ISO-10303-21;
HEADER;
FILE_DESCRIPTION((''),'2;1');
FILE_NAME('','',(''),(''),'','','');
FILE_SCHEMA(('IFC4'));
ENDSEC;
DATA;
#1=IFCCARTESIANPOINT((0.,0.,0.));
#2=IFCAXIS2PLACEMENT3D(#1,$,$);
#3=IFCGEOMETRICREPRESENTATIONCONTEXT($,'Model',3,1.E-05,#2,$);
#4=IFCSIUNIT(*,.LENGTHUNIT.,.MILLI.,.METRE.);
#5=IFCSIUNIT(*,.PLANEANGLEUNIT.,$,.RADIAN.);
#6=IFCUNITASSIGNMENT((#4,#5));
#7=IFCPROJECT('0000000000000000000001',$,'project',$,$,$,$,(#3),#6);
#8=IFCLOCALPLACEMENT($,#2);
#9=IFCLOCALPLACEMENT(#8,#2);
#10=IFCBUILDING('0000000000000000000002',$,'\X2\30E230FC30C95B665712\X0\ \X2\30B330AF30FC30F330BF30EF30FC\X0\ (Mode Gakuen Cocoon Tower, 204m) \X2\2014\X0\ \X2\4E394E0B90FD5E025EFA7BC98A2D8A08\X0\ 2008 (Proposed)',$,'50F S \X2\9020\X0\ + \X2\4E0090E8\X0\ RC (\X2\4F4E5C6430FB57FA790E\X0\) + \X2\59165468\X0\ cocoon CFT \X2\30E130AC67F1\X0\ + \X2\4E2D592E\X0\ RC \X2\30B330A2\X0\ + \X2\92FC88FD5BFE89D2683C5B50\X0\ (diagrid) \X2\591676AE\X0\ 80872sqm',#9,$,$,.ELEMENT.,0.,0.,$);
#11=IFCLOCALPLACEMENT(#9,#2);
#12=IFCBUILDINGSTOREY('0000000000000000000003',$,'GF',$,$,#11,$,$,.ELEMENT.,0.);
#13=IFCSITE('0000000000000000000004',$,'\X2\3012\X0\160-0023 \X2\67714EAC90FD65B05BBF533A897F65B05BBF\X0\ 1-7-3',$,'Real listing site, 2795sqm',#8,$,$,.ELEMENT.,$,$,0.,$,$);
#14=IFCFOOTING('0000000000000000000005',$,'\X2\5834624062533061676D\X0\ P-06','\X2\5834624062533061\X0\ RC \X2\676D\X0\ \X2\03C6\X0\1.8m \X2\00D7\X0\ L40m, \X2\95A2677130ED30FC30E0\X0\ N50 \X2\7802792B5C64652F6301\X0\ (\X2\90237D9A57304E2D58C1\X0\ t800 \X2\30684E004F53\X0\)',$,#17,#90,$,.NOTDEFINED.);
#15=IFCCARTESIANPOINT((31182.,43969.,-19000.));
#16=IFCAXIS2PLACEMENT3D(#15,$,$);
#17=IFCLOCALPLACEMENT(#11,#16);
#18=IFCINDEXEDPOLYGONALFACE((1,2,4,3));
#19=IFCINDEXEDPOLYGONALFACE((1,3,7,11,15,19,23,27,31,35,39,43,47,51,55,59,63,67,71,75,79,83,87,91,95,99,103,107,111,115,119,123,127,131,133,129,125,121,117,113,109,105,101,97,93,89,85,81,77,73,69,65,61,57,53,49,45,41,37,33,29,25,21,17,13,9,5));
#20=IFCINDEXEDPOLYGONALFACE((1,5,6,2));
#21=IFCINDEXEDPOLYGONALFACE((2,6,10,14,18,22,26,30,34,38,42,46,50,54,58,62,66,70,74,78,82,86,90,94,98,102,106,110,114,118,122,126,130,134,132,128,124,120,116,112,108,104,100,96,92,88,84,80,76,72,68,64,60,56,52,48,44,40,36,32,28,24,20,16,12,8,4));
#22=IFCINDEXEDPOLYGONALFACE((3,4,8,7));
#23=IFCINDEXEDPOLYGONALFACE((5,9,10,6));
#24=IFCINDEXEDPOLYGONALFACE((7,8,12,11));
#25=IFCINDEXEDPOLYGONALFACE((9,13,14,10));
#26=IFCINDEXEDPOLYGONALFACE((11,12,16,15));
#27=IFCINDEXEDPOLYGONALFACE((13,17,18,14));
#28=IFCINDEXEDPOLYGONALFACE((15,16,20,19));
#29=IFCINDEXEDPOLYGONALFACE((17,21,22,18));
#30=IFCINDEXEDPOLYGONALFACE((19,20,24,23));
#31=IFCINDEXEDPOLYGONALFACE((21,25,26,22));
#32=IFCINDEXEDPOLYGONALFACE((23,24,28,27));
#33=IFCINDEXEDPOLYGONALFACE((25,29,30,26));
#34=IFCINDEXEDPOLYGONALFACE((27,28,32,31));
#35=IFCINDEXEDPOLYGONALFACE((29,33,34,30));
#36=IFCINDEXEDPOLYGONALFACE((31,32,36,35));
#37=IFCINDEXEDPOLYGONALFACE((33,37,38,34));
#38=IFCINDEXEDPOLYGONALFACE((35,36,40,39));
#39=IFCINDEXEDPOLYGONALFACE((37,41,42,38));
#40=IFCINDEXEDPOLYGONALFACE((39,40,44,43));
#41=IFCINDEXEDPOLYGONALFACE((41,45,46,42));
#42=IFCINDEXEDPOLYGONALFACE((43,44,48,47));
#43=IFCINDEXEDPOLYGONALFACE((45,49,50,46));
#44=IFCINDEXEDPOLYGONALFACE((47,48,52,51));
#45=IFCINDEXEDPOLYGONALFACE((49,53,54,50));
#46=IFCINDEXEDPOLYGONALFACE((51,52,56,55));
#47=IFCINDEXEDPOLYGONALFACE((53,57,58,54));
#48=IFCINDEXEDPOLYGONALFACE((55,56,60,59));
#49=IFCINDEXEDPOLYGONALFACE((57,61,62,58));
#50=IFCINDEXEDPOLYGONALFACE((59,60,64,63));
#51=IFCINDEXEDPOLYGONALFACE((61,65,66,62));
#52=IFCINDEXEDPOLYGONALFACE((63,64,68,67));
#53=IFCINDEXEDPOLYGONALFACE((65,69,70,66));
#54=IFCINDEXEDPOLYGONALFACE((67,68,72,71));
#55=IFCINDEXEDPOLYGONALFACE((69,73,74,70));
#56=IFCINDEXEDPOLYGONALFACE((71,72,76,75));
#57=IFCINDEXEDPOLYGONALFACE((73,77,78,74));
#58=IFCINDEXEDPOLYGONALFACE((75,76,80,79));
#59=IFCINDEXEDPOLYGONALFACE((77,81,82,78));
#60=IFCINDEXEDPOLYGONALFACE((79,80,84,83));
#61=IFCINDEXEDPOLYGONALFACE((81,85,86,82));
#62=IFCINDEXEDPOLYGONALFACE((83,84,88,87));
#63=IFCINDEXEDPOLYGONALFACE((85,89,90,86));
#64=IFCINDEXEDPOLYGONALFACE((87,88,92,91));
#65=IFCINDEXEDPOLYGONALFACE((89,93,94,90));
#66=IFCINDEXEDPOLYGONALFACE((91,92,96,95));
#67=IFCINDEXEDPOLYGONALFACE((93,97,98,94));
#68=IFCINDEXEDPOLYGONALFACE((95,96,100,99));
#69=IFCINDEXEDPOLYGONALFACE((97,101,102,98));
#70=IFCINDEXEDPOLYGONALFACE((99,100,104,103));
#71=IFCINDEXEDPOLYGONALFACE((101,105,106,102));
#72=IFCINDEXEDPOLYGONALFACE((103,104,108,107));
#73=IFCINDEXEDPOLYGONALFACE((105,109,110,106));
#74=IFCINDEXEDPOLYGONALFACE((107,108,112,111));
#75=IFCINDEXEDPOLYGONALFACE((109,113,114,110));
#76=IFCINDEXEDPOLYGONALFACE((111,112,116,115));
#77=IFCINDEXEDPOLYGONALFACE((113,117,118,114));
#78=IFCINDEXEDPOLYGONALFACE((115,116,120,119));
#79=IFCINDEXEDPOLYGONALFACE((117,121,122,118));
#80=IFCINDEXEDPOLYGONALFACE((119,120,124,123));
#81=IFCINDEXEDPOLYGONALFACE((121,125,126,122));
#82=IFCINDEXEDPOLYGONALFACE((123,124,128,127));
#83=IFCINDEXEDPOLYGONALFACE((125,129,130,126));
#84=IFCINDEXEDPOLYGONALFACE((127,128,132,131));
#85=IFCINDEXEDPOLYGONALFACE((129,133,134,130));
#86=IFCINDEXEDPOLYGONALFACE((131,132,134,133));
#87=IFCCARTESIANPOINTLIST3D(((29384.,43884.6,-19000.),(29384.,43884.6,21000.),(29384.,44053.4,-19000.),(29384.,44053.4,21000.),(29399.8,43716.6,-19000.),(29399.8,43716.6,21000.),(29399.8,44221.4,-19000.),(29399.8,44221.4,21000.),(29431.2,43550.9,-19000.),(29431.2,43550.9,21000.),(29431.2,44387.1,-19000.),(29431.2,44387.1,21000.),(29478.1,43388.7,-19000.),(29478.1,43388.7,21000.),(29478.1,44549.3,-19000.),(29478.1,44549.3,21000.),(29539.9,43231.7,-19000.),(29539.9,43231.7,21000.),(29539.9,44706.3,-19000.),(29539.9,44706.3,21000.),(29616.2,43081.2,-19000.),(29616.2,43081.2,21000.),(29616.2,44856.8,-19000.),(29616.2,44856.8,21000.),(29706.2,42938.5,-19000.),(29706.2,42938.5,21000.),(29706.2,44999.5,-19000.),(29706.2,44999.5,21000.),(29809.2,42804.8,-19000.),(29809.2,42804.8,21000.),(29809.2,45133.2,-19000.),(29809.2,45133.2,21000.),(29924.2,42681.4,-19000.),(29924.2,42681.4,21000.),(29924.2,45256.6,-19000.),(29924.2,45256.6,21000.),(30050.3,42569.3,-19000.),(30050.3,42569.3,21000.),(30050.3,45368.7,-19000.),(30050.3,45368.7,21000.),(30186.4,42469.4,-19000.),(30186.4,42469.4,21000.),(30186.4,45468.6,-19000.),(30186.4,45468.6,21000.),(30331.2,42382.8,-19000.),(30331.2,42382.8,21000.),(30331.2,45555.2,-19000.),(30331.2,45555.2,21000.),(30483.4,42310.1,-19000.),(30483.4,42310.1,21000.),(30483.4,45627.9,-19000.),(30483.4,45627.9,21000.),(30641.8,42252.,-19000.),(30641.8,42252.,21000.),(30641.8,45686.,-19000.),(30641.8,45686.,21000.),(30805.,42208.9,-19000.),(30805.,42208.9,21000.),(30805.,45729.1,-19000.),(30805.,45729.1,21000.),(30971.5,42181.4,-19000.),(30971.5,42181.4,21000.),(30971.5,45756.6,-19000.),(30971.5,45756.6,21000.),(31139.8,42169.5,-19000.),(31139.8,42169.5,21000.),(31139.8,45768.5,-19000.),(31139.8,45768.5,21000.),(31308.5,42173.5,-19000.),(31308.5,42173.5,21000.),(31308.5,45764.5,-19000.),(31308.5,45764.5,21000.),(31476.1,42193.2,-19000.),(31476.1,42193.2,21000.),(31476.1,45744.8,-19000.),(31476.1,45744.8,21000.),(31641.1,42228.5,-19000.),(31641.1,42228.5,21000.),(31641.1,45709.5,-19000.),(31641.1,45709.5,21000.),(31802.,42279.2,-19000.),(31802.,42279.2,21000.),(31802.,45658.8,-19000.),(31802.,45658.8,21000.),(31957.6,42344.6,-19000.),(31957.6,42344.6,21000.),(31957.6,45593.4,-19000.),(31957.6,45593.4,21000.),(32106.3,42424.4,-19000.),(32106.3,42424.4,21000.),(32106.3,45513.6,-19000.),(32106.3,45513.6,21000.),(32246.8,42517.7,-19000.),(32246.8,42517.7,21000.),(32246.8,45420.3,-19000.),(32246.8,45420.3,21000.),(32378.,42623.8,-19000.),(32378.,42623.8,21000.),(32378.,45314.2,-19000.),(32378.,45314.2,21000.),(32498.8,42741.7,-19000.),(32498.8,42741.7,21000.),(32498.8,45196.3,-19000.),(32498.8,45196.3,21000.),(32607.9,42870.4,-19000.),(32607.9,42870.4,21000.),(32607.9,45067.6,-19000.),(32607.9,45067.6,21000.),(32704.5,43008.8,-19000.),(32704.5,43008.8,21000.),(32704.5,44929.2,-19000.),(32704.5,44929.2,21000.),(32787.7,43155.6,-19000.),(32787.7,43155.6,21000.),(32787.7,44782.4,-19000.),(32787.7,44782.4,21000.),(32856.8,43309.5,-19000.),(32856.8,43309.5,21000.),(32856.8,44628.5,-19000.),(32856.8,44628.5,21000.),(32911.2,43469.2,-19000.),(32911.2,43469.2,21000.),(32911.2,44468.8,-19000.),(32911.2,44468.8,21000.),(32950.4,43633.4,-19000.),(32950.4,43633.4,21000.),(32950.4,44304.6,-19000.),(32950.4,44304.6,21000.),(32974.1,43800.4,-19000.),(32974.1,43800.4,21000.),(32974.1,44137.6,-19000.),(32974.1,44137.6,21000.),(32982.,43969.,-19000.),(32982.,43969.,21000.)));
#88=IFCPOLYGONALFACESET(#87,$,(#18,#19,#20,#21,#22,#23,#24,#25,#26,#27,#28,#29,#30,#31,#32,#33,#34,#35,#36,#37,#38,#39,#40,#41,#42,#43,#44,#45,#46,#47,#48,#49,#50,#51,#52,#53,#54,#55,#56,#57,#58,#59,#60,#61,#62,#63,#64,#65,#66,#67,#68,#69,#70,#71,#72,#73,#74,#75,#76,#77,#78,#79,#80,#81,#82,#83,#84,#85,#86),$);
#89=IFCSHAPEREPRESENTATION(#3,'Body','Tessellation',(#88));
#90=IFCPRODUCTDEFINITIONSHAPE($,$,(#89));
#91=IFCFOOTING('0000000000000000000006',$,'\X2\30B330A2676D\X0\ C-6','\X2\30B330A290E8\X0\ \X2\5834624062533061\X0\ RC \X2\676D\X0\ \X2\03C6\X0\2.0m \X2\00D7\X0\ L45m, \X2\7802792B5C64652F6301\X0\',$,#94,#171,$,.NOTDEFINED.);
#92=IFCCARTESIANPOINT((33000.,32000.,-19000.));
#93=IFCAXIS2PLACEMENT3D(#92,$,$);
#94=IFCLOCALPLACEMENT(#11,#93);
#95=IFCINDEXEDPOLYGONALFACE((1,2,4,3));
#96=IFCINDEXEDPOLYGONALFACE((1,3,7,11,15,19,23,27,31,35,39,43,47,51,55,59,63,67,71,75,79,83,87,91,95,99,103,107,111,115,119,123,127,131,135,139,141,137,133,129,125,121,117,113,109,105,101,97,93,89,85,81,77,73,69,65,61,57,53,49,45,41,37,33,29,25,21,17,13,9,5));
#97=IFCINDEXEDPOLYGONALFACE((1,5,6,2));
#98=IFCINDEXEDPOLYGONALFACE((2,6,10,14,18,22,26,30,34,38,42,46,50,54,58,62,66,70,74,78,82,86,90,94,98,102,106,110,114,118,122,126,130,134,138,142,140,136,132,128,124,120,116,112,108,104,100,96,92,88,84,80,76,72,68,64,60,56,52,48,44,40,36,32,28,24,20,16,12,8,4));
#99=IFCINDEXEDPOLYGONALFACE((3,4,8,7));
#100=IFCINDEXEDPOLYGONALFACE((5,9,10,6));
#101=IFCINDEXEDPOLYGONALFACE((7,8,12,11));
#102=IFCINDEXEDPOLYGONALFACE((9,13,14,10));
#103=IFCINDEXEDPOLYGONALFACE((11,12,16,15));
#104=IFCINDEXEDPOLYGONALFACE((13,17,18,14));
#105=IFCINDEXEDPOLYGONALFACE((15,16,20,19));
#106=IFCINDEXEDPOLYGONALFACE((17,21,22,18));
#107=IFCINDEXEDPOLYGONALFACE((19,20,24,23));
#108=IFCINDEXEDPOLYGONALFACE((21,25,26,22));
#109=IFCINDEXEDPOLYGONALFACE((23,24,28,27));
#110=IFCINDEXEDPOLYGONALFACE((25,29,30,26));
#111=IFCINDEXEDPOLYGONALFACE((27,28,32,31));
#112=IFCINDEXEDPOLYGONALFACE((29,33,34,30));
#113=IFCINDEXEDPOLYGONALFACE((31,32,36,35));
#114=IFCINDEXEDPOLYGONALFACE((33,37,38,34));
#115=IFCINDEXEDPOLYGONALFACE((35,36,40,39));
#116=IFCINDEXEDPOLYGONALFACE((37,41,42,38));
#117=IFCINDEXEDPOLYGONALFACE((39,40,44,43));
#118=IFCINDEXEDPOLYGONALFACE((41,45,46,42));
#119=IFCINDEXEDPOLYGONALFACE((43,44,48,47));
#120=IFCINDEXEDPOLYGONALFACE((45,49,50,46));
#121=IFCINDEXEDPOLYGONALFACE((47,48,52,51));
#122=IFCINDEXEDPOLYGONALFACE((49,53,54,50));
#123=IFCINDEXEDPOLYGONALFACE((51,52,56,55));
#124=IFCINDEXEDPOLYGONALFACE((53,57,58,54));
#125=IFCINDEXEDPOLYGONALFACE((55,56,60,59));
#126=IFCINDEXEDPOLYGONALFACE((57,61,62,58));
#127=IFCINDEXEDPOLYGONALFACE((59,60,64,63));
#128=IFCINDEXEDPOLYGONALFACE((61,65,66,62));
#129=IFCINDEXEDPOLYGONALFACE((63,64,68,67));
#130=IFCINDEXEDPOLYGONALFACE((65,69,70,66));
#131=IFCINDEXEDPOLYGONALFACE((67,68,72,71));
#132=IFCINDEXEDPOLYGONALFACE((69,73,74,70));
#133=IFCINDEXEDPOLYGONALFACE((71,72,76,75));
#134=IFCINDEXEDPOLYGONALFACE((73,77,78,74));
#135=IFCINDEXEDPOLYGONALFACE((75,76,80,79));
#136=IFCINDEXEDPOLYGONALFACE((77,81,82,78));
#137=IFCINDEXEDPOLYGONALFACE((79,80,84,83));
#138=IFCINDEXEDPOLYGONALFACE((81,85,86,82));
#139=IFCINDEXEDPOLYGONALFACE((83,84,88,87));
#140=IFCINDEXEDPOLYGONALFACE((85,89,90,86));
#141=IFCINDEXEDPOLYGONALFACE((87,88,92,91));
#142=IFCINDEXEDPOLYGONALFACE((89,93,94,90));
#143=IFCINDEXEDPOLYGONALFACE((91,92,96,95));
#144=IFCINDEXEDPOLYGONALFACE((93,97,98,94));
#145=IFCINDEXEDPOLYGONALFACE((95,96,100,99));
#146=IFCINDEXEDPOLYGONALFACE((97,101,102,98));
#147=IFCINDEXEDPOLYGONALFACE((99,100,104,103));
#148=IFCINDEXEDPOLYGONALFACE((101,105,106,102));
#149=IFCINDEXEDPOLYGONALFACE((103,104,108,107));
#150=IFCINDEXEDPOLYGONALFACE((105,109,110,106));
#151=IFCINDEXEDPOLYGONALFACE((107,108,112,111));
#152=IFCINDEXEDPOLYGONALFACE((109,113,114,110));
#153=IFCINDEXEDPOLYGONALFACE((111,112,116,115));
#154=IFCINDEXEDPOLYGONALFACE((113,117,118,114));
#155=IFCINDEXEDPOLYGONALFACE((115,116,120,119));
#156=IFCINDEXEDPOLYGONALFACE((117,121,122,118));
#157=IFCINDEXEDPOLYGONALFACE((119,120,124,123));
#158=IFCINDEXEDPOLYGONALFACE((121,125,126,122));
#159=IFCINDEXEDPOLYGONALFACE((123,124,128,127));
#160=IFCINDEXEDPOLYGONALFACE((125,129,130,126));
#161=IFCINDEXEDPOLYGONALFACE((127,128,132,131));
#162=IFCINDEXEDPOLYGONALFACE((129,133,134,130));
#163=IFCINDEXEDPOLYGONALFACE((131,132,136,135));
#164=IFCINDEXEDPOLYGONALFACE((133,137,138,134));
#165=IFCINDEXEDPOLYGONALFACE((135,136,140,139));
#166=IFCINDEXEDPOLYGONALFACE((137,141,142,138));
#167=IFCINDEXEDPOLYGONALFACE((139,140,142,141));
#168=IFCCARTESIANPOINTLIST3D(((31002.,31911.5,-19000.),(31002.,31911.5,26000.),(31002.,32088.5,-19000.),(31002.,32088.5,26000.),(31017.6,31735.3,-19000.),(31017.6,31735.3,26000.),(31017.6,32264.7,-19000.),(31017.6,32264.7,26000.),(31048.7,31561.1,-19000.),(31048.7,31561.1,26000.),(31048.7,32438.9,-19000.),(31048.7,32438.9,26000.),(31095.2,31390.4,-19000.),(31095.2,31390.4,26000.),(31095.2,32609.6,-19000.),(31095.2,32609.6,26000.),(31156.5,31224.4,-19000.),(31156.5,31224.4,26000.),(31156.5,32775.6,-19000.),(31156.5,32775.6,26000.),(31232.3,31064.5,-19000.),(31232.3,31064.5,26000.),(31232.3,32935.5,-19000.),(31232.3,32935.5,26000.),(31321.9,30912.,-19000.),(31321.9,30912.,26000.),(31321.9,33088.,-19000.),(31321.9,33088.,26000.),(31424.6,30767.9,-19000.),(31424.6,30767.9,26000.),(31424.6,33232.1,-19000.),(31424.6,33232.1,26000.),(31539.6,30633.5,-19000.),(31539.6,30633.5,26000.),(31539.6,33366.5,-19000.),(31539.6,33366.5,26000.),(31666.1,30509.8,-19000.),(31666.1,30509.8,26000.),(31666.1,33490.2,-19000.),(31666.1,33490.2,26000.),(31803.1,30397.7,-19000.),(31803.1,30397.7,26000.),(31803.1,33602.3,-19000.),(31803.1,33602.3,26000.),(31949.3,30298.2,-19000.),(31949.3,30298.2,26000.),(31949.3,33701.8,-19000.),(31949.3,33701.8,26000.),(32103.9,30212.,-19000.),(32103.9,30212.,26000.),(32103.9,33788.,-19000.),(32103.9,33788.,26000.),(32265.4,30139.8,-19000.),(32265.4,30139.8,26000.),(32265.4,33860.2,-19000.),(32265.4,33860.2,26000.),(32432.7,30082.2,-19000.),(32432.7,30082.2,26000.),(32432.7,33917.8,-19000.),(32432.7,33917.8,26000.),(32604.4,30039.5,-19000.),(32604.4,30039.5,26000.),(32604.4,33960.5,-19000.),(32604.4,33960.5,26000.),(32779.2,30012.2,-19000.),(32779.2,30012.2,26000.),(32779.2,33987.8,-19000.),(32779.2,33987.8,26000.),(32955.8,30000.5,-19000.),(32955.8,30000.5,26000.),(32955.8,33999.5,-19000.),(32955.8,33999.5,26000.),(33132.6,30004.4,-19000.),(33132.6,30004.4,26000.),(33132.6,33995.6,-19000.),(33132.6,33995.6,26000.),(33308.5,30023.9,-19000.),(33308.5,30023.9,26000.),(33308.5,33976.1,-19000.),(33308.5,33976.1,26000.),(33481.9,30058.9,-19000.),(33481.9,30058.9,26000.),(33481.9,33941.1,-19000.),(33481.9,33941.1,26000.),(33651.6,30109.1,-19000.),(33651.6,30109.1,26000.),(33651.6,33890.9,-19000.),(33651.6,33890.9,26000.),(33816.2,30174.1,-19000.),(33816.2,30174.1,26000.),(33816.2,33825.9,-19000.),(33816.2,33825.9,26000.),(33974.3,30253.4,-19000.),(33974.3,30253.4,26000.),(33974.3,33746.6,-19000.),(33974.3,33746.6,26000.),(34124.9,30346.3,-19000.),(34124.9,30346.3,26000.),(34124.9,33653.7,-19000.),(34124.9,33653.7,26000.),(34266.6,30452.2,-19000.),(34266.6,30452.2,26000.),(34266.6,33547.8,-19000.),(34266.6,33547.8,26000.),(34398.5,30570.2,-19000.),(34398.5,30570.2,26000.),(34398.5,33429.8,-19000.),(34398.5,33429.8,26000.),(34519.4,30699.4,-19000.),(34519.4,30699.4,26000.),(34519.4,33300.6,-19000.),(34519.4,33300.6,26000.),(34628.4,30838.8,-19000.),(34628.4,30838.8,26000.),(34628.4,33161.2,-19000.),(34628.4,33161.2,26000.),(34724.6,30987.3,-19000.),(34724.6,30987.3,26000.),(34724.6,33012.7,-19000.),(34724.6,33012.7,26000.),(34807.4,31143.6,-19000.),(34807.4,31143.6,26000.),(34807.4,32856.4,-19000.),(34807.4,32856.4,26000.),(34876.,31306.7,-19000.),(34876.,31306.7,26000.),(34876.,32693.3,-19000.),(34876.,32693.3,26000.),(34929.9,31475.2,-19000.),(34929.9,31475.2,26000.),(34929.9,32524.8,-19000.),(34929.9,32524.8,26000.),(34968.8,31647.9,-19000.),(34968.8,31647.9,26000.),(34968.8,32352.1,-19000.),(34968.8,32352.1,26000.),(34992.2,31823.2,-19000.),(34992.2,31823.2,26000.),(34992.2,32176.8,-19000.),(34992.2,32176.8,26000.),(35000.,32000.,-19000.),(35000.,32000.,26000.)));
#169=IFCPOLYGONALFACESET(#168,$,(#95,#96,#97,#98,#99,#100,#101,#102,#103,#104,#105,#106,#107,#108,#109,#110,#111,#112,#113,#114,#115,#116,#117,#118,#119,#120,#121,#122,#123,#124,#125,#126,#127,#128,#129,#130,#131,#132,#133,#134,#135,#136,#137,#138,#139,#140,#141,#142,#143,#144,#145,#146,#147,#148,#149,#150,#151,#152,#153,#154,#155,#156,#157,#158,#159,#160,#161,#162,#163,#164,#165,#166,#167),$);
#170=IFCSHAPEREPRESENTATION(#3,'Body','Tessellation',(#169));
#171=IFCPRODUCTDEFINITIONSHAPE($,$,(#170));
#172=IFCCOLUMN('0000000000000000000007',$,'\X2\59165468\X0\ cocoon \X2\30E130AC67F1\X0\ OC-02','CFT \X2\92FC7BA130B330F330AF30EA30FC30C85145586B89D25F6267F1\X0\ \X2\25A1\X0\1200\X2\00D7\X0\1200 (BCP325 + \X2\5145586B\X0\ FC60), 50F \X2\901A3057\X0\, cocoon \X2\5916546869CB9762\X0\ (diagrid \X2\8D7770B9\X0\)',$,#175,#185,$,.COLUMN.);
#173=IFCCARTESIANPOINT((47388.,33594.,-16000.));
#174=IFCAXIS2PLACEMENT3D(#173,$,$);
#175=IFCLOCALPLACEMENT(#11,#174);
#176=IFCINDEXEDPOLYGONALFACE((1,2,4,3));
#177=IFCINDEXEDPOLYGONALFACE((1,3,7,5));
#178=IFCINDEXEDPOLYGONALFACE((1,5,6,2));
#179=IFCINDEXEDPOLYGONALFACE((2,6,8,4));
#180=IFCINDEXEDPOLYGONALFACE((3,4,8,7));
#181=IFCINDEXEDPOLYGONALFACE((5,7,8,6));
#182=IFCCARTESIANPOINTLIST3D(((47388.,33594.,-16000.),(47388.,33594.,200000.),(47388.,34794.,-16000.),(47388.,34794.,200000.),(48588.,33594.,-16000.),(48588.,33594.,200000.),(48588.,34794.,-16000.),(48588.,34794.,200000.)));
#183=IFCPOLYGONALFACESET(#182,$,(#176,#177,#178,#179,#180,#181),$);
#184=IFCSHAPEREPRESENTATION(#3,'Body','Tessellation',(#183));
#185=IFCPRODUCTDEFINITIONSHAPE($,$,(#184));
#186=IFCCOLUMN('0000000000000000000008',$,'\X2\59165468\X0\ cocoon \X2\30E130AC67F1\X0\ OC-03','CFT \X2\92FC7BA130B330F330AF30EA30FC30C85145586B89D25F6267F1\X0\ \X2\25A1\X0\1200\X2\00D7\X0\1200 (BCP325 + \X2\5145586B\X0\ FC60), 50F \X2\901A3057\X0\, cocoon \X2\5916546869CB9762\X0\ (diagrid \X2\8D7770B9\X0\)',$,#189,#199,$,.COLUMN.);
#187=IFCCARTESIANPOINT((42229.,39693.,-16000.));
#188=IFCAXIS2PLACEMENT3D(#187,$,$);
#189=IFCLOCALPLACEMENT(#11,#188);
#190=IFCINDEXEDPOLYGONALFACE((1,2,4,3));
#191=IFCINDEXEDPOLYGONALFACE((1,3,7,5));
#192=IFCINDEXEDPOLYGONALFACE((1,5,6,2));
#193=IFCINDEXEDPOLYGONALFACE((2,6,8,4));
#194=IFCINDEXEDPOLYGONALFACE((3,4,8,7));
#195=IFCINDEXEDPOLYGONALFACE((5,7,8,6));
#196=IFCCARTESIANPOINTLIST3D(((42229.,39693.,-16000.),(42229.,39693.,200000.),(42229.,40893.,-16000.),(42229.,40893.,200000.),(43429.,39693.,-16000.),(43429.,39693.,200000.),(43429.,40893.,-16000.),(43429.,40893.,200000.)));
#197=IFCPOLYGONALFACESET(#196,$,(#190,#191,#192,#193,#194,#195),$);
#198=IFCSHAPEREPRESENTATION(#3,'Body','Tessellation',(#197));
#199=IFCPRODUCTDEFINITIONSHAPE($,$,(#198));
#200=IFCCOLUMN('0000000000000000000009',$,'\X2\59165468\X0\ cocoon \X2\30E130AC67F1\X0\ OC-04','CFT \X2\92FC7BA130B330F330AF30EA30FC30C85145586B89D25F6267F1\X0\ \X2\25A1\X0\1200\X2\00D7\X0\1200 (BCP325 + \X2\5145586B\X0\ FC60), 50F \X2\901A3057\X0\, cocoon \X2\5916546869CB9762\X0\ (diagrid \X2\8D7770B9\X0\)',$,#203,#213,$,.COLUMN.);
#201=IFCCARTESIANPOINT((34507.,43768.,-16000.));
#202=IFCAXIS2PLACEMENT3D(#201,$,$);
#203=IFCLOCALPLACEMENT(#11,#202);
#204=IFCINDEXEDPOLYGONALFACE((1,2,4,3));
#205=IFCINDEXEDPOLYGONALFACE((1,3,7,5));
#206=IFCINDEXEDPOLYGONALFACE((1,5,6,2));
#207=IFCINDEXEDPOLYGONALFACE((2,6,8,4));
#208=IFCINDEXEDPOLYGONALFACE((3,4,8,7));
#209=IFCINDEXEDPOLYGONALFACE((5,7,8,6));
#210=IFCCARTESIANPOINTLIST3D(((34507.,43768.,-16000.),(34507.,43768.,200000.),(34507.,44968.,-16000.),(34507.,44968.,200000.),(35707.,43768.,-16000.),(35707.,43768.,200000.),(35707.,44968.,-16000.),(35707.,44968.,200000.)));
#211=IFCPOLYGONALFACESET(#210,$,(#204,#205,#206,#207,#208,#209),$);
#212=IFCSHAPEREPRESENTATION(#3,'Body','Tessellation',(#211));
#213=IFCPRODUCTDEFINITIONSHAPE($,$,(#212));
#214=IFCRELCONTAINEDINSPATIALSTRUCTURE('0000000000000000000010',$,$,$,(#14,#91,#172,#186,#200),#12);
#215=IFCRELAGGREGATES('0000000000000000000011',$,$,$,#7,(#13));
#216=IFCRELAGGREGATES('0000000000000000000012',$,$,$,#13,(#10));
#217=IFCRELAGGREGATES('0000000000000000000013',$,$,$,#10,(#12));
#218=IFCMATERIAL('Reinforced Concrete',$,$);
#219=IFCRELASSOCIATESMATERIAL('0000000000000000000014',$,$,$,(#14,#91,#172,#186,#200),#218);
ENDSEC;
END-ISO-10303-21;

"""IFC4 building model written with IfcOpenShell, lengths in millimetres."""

from ifc_helpers import new_model, si_unit, frame, frame_2d, origin, origin_2d, place, context, project, spatial, rectangle, circle, extrude, material, element, save


model = new_model("IFC4")

# Units and contexts
model_context = context("Model", 3, precision=1e-05, world=origin())
ifc_project = project(units=[si_unit("LENGTHUNIT", "METRE", prefix="MILLI"), si_unit("PLANEANGLEUNIT", "RADIAN")], contexts=[model_context])

# Site, building, storey
site_placement = place(None, origin())
site = spatial("IfcSite", under=ifc_project, at=site_placement, Name="〒160-0023 東京都新宿区西新宿 1-7-3", ObjectType="Real listing site, 2795sqm", CompositionType="ELEMENT", RefElevation=0.0)
building_placement = place(site_placement, origin())
building = spatial("IfcBuilding", under=site, at=building_placement, Name="モード学園 コクーンタワー (Mode Gakuen Cocoon Tower, 204m) — 丹下都市建築設計 2008 (Proposed)", ObjectType="50F S 造 + 一部 RC (低層・基礎) + 外周 cocoon CFT メガ柱 + 中央 RC コア + 鋼製対角格子 (diagrid) 外皮 80872sqm", CompositionType="ELEMENT", ElevationOfRefHeight=0.0, ElevationOfTerrain=0.0)
storey_placement = place(building_placement, origin())
storey = spatial("IfcBuildingStorey", under=building, at=storey_placement, Name="GF", CompositionType="ELEMENT", Elevation=0.0)

# Footings
ifc_material_1 = material(Name="Reinforced Concrete")
footing_1_placement = place(storey_placement, frame((31182.0, 43969.0, -19000.0)))
element("IfcFooting", 1, at=footing_1_placement, inside=storey, material=ifc_material_1, Name="場所打ち杭 P-06", Description="場所打ち RC 杭 φ1.8m × L40m, 関東ローム N50 砂礫層支持 (連続地中壁 t800 と一体)", PredefinedType="NOTDEFINED", context=model_context, shape_type="SweptSolid", body=[
    extrude(circle(Radius=1800.0, at=origin_2d()), frame((31182.0, 43969.0, -19000.0)), (0.0, 0.0, 1.0), 40000.0),
])
footing_2_placement = place(storey_placement, frame((33000.0, 32000.0, -19000.0)))
element("IfcFooting", 2, at=footing_2_placement, inside=storey, material=ifc_material_1, Name="コア杭 C-6", Description="コア部 場所打ち RC 杭 φ2.0m × L45m, 砂礫層支持", PredefinedType="NOTDEFINED", context=model_context, shape_type="SweptSolid", body=[
    extrude(circle(Radius=2000.0, at=origin_2d()), frame((33000.0, 32000.0, -19000.0)), (0.0, 0.0, 1.0), 45000.0),
])

# Columns
column_1_placement = place(storey_placement, frame((47388.0, 33594.0, -16000.0)))
element("IfcColumn", 3, at=column_1_placement, inside=storey, material=ifc_material_1, Name="外周 cocoon メガ柱 OC-02", Description="CFT 鋼管コンクリート充填角形柱 □1200×1200 (BCP325 + 充填 FC60), 50F 通し, cocoon 外周構面 (diagrid 起点)", PredefinedType="COLUMN", context=model_context, shape_type="SweptSolid", body=[
    extrude(rectangle(XDim=1200.0, YDim=1200.0, at=frame_2d((600.0, 600.0))), frame((47388.0, 33594.0, -16000.0)), (0.0, 0.0, 1.0), 216000.0),
])
column_2_placement = place(storey_placement, frame((42229.0, 39693.0, -16000.0)))
element("IfcColumn", 4, at=column_2_placement, inside=storey, material=ifc_material_1, Name="外周 cocoon メガ柱 OC-03", Description="CFT 鋼管コンクリート充填角形柱 □1200×1200 (BCP325 + 充填 FC60), 50F 通し, cocoon 外周構面 (diagrid 起点)", PredefinedType="COLUMN", context=model_context, shape_type="SweptSolid", body=[
    extrude(rectangle(XDim=1200.0, YDim=1200.0, at=frame_2d((600.0, 600.0))), frame((42229.0, 39693.0, -16000.0)), (0.0, 0.0, 1.0), 216000.0),
])
column_3_placement = place(storey_placement, frame((34507.0, 43768.0, -16000.0)))
element("IfcColumn", 5, at=column_3_placement, inside=storey, material=ifc_material_1, Name="外周 cocoon メガ柱 OC-04", Description="CFT 鋼管コンクリート充填角形柱 □1200×1200 (BCP325 + 充填 FC60), 50F 通し, cocoon 外周構面 (diagrid 起点)", PredefinedType="COLUMN", context=model_context, shape_type="SweptSolid", body=[
    extrude(rectangle(XDim=1200.0, YDim=1200.0, at=frame_2d((600.0, 600.0))), frame((34507.0, 43768.0, -16000.0)), (0.0, 0.0, 1.0), 216000.0),
])

save(model, "model.ifc")
